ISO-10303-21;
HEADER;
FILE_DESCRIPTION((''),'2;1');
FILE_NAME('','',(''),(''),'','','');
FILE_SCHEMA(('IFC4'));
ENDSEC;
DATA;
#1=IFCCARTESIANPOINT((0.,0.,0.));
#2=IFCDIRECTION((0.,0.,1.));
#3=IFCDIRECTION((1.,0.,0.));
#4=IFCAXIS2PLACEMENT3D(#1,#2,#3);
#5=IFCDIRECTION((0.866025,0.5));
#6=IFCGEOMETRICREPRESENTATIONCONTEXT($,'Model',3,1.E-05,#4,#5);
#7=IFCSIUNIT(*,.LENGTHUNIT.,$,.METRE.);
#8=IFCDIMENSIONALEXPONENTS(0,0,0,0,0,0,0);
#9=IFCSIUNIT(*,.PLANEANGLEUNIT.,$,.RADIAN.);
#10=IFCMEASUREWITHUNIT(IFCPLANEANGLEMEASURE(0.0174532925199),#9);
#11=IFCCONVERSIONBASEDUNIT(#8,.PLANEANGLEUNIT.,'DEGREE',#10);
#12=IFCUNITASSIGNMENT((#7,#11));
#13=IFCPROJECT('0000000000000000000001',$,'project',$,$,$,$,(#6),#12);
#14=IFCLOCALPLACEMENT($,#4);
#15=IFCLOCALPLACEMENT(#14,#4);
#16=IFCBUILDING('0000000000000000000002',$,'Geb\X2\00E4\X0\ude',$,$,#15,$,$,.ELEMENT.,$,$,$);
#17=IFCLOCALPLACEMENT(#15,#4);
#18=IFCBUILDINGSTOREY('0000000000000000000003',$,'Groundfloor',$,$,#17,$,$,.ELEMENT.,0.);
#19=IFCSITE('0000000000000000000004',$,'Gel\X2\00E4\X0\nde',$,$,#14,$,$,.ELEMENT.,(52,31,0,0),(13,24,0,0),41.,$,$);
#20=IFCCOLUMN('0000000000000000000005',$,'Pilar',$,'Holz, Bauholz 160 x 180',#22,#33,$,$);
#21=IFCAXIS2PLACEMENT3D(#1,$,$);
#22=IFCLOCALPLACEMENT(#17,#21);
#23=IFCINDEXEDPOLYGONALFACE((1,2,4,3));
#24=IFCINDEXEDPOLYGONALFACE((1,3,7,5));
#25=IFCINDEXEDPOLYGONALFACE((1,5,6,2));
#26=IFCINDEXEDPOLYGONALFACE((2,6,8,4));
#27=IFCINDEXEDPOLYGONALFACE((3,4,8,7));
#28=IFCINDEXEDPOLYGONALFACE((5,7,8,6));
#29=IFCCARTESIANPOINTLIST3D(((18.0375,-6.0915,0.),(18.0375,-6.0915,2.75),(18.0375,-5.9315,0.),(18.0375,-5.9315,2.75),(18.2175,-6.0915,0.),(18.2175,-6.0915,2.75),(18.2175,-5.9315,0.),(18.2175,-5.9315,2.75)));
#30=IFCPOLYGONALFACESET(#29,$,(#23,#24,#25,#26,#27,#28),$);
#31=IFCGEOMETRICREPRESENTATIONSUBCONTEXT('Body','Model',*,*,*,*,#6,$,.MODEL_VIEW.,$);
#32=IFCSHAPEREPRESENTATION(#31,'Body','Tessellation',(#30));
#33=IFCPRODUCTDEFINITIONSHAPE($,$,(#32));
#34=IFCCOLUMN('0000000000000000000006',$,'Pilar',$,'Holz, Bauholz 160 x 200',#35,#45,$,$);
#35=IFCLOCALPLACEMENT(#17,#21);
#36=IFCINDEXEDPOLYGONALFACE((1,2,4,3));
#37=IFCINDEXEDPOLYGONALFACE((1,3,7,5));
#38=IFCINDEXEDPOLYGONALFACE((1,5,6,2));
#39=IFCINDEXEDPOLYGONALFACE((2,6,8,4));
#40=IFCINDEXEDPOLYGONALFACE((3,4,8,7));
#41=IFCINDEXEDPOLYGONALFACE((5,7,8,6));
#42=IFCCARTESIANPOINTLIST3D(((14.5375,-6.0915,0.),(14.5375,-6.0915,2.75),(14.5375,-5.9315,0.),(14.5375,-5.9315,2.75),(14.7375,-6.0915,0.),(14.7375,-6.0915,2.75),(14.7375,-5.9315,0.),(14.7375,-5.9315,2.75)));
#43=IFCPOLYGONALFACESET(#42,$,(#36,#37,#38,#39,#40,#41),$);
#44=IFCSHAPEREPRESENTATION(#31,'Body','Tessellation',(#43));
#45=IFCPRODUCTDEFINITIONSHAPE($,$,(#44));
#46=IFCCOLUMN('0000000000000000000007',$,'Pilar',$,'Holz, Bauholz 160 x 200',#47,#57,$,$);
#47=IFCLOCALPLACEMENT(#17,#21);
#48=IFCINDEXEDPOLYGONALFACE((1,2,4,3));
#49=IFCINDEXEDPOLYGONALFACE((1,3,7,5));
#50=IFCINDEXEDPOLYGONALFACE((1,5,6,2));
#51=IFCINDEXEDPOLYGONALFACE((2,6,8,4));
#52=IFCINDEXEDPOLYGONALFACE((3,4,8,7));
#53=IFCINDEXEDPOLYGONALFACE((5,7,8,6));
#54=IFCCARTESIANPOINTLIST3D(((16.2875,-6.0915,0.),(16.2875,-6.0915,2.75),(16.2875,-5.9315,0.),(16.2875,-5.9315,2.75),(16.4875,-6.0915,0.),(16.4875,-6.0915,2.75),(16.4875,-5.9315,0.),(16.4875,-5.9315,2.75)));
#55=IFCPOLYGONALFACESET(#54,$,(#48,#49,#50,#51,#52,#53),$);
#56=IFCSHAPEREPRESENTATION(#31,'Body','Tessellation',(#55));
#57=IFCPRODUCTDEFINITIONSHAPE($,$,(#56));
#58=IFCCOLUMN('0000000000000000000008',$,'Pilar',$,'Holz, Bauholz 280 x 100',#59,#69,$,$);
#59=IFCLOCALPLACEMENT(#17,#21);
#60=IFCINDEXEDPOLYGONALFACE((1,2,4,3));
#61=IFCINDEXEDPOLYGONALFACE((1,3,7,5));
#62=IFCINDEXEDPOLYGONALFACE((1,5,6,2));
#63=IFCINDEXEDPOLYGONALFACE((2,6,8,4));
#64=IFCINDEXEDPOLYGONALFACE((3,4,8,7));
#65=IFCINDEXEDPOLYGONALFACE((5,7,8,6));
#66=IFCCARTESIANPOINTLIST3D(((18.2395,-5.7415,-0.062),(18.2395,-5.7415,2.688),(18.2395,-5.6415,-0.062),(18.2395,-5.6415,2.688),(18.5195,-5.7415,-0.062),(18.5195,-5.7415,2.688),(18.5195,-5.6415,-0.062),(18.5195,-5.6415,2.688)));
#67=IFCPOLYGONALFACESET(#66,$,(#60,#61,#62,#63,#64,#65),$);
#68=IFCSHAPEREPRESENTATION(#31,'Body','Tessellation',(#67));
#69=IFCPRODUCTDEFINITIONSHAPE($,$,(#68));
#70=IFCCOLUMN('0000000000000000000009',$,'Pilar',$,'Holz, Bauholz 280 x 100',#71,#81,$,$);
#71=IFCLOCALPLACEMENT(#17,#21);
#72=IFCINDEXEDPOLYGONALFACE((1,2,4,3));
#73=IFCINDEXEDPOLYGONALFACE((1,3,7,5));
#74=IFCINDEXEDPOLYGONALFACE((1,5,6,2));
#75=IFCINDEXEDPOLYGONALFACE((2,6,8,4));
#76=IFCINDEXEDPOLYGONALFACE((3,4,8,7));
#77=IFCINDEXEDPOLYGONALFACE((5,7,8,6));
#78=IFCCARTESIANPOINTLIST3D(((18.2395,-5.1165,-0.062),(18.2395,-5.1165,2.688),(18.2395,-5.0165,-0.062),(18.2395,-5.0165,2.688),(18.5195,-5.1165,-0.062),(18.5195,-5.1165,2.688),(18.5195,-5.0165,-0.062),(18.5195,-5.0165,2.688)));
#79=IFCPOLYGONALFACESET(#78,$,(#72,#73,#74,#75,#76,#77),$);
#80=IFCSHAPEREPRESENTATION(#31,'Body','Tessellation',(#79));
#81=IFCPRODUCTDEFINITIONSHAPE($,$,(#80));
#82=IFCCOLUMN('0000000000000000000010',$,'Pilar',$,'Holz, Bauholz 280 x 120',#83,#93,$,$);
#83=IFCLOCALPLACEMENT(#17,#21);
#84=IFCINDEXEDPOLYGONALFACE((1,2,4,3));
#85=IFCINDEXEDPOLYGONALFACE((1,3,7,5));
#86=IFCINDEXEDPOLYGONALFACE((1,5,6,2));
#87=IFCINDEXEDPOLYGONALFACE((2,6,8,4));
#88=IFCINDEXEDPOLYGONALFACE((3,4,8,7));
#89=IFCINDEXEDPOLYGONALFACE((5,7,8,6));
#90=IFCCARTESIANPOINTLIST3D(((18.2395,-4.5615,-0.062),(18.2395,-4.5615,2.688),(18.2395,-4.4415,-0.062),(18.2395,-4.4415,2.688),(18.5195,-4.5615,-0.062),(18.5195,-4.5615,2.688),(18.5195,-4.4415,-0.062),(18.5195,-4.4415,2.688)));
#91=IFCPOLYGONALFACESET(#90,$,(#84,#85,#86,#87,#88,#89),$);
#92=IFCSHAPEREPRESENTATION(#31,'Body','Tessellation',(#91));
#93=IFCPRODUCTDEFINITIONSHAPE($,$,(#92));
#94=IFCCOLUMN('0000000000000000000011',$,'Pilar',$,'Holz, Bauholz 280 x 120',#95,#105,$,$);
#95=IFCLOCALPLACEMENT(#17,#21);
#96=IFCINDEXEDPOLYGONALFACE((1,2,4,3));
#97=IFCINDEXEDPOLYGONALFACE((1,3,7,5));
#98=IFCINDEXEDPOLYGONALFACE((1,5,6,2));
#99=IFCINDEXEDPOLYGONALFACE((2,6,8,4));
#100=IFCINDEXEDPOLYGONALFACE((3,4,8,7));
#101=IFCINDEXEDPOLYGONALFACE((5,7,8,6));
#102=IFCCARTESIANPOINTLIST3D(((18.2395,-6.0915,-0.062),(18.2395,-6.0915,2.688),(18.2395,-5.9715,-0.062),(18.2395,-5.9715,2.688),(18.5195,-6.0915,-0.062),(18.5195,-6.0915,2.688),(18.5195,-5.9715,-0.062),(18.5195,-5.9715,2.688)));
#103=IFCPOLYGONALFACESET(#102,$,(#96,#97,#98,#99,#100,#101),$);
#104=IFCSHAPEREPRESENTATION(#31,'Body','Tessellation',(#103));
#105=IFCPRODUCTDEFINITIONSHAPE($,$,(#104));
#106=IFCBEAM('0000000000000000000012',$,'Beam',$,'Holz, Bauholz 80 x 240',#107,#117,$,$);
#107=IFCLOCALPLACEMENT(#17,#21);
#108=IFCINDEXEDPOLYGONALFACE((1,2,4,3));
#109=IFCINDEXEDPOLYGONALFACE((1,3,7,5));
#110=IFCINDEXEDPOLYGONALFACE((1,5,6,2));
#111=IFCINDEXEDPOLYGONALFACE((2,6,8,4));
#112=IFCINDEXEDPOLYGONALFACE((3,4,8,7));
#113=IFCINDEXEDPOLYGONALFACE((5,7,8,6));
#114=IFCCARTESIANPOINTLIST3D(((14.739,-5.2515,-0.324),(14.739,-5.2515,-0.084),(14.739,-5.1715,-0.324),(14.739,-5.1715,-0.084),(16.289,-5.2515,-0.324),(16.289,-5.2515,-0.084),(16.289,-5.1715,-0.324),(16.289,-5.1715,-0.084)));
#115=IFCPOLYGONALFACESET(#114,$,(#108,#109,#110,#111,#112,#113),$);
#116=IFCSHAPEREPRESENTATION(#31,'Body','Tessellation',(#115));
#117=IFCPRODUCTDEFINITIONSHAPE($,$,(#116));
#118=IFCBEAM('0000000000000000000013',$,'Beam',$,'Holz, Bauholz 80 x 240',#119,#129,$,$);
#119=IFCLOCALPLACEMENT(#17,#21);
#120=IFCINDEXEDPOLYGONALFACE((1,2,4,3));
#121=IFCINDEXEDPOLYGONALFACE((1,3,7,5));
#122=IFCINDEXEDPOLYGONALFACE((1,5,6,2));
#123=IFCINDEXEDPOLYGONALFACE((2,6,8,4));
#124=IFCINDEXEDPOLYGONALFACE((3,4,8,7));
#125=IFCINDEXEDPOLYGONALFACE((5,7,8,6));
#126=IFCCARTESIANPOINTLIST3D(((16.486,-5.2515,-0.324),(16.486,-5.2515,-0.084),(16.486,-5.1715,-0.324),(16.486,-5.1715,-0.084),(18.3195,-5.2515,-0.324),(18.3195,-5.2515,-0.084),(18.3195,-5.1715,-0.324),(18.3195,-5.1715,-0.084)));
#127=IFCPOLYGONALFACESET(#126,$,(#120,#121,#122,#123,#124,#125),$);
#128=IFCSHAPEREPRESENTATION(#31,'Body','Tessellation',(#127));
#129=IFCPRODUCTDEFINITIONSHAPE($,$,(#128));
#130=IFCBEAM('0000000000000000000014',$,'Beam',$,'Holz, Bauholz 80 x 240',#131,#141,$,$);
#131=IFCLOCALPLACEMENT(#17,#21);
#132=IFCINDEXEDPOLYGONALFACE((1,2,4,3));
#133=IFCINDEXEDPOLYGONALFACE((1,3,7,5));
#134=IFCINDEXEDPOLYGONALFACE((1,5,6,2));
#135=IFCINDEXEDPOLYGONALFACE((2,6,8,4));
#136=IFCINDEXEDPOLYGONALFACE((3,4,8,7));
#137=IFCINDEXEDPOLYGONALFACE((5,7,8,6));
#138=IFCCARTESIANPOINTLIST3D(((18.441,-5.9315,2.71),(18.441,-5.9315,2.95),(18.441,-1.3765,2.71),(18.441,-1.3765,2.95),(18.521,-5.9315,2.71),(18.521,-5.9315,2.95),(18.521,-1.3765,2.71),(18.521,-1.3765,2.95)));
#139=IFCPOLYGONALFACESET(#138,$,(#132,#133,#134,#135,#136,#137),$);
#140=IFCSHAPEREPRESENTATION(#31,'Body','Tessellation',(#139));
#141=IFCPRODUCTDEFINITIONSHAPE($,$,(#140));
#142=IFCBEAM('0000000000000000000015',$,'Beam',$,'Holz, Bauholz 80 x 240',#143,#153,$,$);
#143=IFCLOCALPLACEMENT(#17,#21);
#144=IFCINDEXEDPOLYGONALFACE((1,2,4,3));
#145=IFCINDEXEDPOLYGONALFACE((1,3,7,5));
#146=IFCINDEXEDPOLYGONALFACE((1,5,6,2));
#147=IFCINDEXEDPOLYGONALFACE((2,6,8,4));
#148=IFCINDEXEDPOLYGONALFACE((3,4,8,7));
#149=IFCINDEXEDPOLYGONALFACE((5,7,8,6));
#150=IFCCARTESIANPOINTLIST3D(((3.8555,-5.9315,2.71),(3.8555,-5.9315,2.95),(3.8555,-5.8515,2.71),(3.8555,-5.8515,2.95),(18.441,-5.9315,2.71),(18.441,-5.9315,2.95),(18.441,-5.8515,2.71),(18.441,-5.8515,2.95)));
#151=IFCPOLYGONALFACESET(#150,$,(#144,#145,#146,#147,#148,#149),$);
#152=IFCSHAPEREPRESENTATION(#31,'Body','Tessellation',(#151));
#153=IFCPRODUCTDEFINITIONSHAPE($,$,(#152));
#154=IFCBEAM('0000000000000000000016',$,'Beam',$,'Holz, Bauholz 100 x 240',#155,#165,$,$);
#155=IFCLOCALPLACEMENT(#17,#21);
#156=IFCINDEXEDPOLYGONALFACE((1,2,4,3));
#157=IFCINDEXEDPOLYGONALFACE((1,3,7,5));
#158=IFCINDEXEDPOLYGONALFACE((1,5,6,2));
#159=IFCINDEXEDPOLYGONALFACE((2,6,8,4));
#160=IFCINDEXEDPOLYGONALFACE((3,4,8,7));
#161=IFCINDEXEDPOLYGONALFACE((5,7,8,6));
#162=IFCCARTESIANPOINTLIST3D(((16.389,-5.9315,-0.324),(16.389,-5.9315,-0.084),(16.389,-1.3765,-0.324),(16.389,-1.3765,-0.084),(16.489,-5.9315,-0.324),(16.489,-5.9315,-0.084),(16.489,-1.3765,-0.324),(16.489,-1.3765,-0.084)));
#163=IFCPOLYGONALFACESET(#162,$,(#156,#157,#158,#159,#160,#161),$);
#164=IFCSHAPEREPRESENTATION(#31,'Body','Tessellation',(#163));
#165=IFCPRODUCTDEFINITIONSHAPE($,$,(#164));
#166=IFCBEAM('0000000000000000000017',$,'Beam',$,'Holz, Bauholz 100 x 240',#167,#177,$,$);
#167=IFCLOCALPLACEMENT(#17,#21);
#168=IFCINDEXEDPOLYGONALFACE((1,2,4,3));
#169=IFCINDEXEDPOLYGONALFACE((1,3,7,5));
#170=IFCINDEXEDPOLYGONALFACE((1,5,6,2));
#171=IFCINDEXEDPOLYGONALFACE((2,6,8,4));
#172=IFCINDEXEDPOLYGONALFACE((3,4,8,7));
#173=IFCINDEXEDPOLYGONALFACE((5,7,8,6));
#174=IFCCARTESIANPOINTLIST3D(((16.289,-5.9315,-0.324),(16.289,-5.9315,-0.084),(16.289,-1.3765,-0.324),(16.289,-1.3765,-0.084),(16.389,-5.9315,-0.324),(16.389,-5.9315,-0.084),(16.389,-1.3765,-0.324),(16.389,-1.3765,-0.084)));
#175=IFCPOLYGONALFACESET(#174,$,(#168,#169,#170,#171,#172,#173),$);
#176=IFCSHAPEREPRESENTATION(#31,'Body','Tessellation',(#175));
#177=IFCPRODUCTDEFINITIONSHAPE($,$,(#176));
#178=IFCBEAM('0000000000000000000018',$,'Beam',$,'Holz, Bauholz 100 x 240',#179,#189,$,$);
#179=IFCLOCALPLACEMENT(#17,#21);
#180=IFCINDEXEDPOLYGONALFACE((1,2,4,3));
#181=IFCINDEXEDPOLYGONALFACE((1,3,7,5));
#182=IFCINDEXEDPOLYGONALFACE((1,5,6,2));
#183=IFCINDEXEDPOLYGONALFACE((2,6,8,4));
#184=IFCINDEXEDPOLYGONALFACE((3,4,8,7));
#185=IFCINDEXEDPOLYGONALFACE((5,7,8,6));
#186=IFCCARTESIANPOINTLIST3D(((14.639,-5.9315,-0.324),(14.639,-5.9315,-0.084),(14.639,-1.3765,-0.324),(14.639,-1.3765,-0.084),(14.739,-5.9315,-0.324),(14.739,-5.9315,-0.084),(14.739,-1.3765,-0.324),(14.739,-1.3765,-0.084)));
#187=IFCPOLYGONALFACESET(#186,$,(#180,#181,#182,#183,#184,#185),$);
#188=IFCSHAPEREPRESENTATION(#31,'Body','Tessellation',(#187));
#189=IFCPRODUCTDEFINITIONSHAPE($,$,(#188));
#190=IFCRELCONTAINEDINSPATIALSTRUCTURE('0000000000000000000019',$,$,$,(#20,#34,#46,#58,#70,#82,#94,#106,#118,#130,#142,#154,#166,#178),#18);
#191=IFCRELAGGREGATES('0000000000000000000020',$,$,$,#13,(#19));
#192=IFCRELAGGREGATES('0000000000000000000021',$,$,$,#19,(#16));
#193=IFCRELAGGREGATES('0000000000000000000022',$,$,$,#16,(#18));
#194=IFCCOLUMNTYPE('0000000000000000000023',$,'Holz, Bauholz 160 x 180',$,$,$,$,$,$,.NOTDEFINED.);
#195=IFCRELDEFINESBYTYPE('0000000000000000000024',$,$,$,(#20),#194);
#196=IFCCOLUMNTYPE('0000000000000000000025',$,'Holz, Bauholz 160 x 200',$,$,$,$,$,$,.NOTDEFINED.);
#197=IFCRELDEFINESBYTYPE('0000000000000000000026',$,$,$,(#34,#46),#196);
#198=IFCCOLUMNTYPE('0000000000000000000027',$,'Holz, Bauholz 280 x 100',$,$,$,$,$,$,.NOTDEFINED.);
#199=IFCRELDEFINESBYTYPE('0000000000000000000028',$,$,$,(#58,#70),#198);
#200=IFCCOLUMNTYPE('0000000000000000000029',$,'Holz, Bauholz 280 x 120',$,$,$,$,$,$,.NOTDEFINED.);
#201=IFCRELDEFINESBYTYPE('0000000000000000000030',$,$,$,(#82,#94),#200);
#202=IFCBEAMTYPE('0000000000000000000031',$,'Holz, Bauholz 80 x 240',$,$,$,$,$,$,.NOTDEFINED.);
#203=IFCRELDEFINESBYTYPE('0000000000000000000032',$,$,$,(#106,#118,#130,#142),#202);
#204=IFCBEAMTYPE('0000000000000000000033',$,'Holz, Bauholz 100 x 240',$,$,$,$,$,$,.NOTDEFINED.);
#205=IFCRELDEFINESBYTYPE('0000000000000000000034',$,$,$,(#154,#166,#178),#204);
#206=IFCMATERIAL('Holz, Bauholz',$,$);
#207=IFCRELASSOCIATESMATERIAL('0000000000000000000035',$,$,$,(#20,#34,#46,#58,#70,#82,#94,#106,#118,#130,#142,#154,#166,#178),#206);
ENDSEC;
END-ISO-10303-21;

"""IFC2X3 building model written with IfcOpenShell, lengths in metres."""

from ifc_helpers import new_model, entity, si_unit, converted_unit, direction, frame, frame_2d, origin_with_axes, origin_2d_with_axis, place, context, subcontext, project, spatial, rectangle, extrude, clip, halfspace, material, type_object, element, save


model = new_model("IFC2X3")

# Units and contexts
model_context = context("Model", 3, precision=1e-05, world=origin_with_axes(), true_north=direction((0.866025, 0.5)))
body_context = subcontext(model_context, "Body", "Model", "MODEL_VIEW")
ifc_project = project(units=[si_unit("LENGTHUNIT", "METRE"), converted_unit("PLANEANGLEUNIT", "DEGREE", entity("IfcPlaneAngleMeasure", 0.0174532925199), si_unit("PLANEANGLEUNIT", "RADIAN"), dimensions=[0, 0, 0, 0, 0, 0, 0])], contexts=[model_context])

# Site, building, storey
site_placement = place(None, origin_with_axes())
site = spatial("IfcSite", under=ifc_project, at=site_placement, Name="Gelände", CompositionType="ELEMENT", RefLatitude=(52, 31, 0, 0), RefLongitude=(13, 24, 0, 0), RefElevation=41.0)
building_placement = place(site_placement, origin_with_axes())
building = spatial("IfcBuilding", under=site, at=building_placement, Name="Gebäude", CompositionType="ELEMENT")
storey_placement = place(building_placement, origin_with_axes())
storey = spatial("IfcBuildingStorey", under=building, at=storey_placement, Name="Groundfloor", CompositionType="ELEMENT", Elevation=0.0)

# Columns
ifc_material = material(Name="Holz, Bauholz")
column_type_1 = type_object("IfcColumnType", Name="Holz, Bauholz 160 x 180", PredefinedType="NOTDEFINED")
column_placement = place(storey_placement, frame((18.1275, -6.0115, 0.0), z_axis=(0.0, 0.0, 1.0), x_axis=(1.0, 0.0, 0.0)))
element("IfcColumn", 1, at=column_placement, inside=storey, type_object=column_type_1, material=ifc_material, Name="Pilar", ObjectType="Holz, Bauholz 160 x 180", context=body_context, shape_type="Clipping", body=[
    clip(clip(extrude(rectangle(XDim=0.16, YDim=0.18, at=origin_2d_with_axis()), frame((0.0, 0.0, 0.0), z_axis=(0.0, 0.0, 1.0), x_axis=(0.0, 1.0, 0.0)), (0.0, 0.0, 1.0), 2.75), halfspace(frame((0.0, 0.0, 2.75), z_axis=(0.0, 0.0, -1.0), x_axis=(0.0, 1.0, 0.0)), True)), halfspace(frame((0.0, 0.0, 0.0), z_axis=(0.0, 0.0, 1.0), x_axis=(0.0, -1.0, 0.0)), True)),
])
column_type_2 = type_object("IfcColumnType", Name="Holz, Bauholz 160 x 200", PredefinedType="NOTDEFINED")
for number, where, z_axis, x_axis, name in (
    (2, (14.6375, -6.0115, 0.0), (0.0, 0.0, 1.0), (1.0, 0.0, 0.0), "Pilar"),
    (3, (16.3875, -6.0115, 0.0), (0.0, 0.0, 1.0), (1.0, 0.0, 0.0), "Pilar"),
):
    element("IfcColumn", number, at=place(storey_placement, frame(where, z_axis=z_axis, x_axis=x_axis)), inside=storey, type_object=column_type_2, material=ifc_material, Name=name, ObjectType="Holz, Bauholz 160 x 200", context=body_context, shape_type="Clipping", body=[
        clip(clip(extrude(rectangle(XDim=0.16, YDim=0.2, at=origin_2d_with_axis()), frame((0.0, 0.0, 0.0), z_axis=(0.0, 0.0, 1.0), x_axis=(0.0, 1.0, 0.0)), (0.0, 0.0, 1.0), 2.75), halfspace(frame((0.0, 0.0, 2.75), z_axis=(0.0, 0.0, -1.0), x_axis=(0.0, 1.0, 0.0)), True)), halfspace(frame((0.0, 0.0, 0.0), z_axis=(0.0, 0.0, 1.0), x_axis=(0.0, -1.0, 0.0)), True)),
    ])
column_type_3 = type_object("IfcColumnType", Name="Holz, Bauholz 280 x 100", PredefinedType="NOTDEFINED")
for number, where, z_axis, x_axis, name in (
    (4, (18.3795, -5.6915, -0.062), (0.0, 0.0, 1.0), (0.0, 1.0, 0.0), "Pilar"),
    (5, (18.3795, -5.0665, -0.062), (0.0, 0.0, 1.0), (0.0, 1.0, 0.0), "Pilar"),
):
    element("IfcColumn", number, at=place(storey_placement, frame(where, z_axis=z_axis, x_axis=x_axis)), inside=storey, type_object=column_type_3, material=ifc_material, Name=name, ObjectType="Holz, Bauholz 280 x 100", context=body_context, shape_type="Clipping", body=[
        clip(clip(extrude(rectangle(XDim=0.28, YDim=0.1, at=origin_2d_with_axis()), frame((0.0, 0.0, 0.0), z_axis=(0.0, 0.0, 1.0), x_axis=(0.0, 1.0, 0.0)), (0.0, 0.0, 1.0), 2.75), halfspace(frame((0.0, 0.0, 2.75), z_axis=(0.0, 0.0, -1.0), x_axis=(0.0, 1.0, 0.0)), True)), halfspace(frame((0.0, 0.0, 0.0), z_axis=(0.0, 0.0, 1.0), x_axis=(0.0, -1.0, 0.0)), True)),
    ])
column_type_4 = type_object("IfcColumnType", Name="Holz, Bauholz 280 x 120", PredefinedType="NOTDEFINED")
for number, where, z_axis, x_axis, name in (
    (6, (18.3795, -4.5015, -0.062), (0.0, 0.0, 1.0), (0.0, 1.0, 0.0), "Pilar"),
    (7, (18.3795, -6.0315, -0.062), (0.0, 0.0, 1.0), (0.0, 1.0, 0.0), "Pilar"),
):
    element("IfcColumn", number, at=place(storey_placement, frame(where, z_axis=z_axis, x_axis=x_axis)), inside=storey, type_object=column_type_4, material=ifc_material, Name=name, ObjectType="Holz, Bauholz 280 x 120", context=body_context, shape_type="Clipping", body=[
        clip(clip(extrude(rectangle(XDim=0.28, YDim=0.12, at=origin_2d_with_axis()), frame((0.0, 0.0, 0.0), z_axis=(0.0, 0.0, 1.0), x_axis=(0.0, 1.0, 0.0)), (0.0, 0.0, 1.0), 2.75), halfspace(frame((0.0, 0.0, 2.75), z_axis=(0.0, 0.0, -1.0), x_axis=(0.0, 1.0, 0.0)), True)), halfspace(frame((0.0, 0.0, 0.0), z_axis=(0.0, 0.0, 1.0), x_axis=(0.0, -1.0, 0.0)), True)),
    ])

# Beams
beam_type_1 = type_object("IfcBeamType", Name="Holz, Bauholz 80 x 240", PredefinedType="NOTDEFINED")
beam_1_placement = place(storey_placement, frame((16.289, -5.2115, -0.084), z_axis=(0.0, 0.0, 1.0), x_axis=(0.0, 1.0, 0.0)))
element("IfcBeam", 8, at=beam_1_placement, inside=storey, type_object=beam_type_1, material=ifc_material, Name="Beam", ObjectType="Holz, Bauholz 80 x 240", context=body_context, shape_type="SweptSolid", body=[
    extrude(rectangle(XDim=0.24, YDim=0.08, at=frame_2d((-0.12, 0.0), x_axis=(1.0, 0.0))), frame((0.0, 0.0, 0.0), z_axis=(0.0, 1.0, 0.0), x_axis=(0.0, 0.0, 1.0)), (0.0, 0.0, 1.0), 1.55),
])
beam_2_placement = place(storey_placement, frame((18.3195, -5.2115, -0.084), z_axis=(0.0, 0.0, 1.0), x_axis=(0.0, 1.0, 0.0)))
element("IfcBeam", 9, at=beam_2_placement, inside=storey, type_object=beam_type_1, material=ifc_material, Name="Beam", ObjectType="Holz, Bauholz 80 x 240", context=body_context, shape_type="SweptSolid", body=[
    extrude(rectangle(XDim=0.24, YDim=0.08, at=frame_2d((-0.12, 0.0), x_axis=(1.0, 0.0))), frame((0.0, 0.0, 0.0), z_axis=(0.0, 1.0, 0.0), x_axis=(0.0, 0.0, 1.0)), (0.0, 0.0, 1.0), 1.8335),
])
beam_3_placement = place(storey_placement, frame((18.481, -5.9315, 2.95), z_axis=(0.0, 0.0, 1.0), x_axis=(1.0, 0.0, 0.0)))
element("IfcBeam", 10, at=beam_3_placement, inside=storey, type_object=beam_type_1, material=ifc_material, Name="Beam", ObjectType="Holz, Bauholz 80 x 240", context=body_context, shape_type="SweptSolid", body=[
    extrude(rectangle(XDim=0.24, YDim=0.08, at=frame_2d((-0.12, 0.0), x_axis=(1.0, 0.0))), frame((0.0, 0.0, 0.0), z_axis=(0.0, 1.0, 0.0), x_axis=(0.0, 0.0, 1.0)), (0.0, 0.0, 1.0), 4.555),
])
beam_4_placement = place(storey_placement, frame((18.441, -5.8915, 2.95), z_axis=(0.0, 0.0, 1.0), x_axis=(0.0, 1.0, 0.0)))
element("IfcBeam", 11, at=beam_4_placement, inside=storey, type_object=beam_type_1, material=ifc_material, Name="Beam", ObjectType="Holz, Bauholz 80 x 240", context=body_context, shape_type="SweptSolid", body=[
    extrude(rectangle(XDim=0.24, YDim=0.08, at=frame_2d((-0.12, 0.0), x_axis=(1.0, 0.0))), frame((0.0, 0.0, 0.0), z_axis=(0.0, 1.0, 0.0), x_axis=(0.0, 0.0, 1.0)), (0.0, 0.0, 1.0), 14.5855),
])
beam_type_2 = type_object("IfcBeamType", Name="Holz, Bauholz 100 x 240", PredefinedType="NOTDEFINED")
beam_5_placement = place(storey_placement, frame((16.439, -5.9315, -0.084), z_axis=(0.0, 0.0, 1.0), x_axis=(1.0, 0.0, 0.0)))
element("IfcBeam", 12, at=beam_5_placement, inside=storey, type_object=beam_type_2, material=ifc_material, Name="Beam", ObjectType="Holz, Bauholz 100 x 240", context=body_context, shape_type="SweptSolid", body=[
    extrude(rectangle(XDim=0.24, YDim=0.1, at=frame_2d((-0.12, 0.0), x_axis=(1.0, 0.0))), frame((0.0, 0.0, 0.0), z_axis=(0.0, 1.0, 0.0), x_axis=(0.0, 0.0, 1.0)), (0.0, 0.0, 1.0), 4.555),
])
beam_6_placement = place(storey_placement, frame((16.339, -5.9315, -0.084), z_axis=(0.0, 0.0, 1.0), x_axis=(1.0, 0.0, 0.0)))
element("IfcBeam", 13, at=beam_6_placement, inside=storey, type_object=beam_type_2, material=ifc_material, Name="Beam", ObjectType="Holz, Bauholz 100 x 240", context=body_context, shape_type="SweptSolid", body=[
    extrude(rectangle(XDim=0.24, YDim=0.1, at=frame_2d((-0.12, 0.0), x_axis=(1.0, 0.0))), frame((0.0, 0.0, 0.0), z_axis=(0.0, 1.0, 0.0), x_axis=(0.0, 0.0, 1.0)), (0.0, 0.0, 1.0), 4.555),
])
for number, where, z_axis, x_axis, name in (
    (14, (14.689, -5.9315, -0.084), (0.0, 0.0, 1.0), (1.0, 0.0, 0.0), "Beam"),
):
    element("IfcBeam", number, at=place(storey_placement, frame(where, z_axis=z_axis, x_axis=x_axis)), inside=storey, type_object=beam_type_2, material=ifc_material, Name=name, ObjectType="Holz, Bauholz 100 x 240", context=body_context, shape_type="SweptSolid", body=[
        extrude(rectangle(XDim=0.24, YDim=0.1, at=frame_2d((-0.12, 0.0), x_axis=(1.0, 0.0))), frame((0.0, 0.0, 0.0), z_axis=(0.0, 1.0, 0.0), x_axis=(0.0, 0.0, 1.0)), (0.0, 0.0, 1.0), 4.555),
    ])

save(model, "model.ifc")
